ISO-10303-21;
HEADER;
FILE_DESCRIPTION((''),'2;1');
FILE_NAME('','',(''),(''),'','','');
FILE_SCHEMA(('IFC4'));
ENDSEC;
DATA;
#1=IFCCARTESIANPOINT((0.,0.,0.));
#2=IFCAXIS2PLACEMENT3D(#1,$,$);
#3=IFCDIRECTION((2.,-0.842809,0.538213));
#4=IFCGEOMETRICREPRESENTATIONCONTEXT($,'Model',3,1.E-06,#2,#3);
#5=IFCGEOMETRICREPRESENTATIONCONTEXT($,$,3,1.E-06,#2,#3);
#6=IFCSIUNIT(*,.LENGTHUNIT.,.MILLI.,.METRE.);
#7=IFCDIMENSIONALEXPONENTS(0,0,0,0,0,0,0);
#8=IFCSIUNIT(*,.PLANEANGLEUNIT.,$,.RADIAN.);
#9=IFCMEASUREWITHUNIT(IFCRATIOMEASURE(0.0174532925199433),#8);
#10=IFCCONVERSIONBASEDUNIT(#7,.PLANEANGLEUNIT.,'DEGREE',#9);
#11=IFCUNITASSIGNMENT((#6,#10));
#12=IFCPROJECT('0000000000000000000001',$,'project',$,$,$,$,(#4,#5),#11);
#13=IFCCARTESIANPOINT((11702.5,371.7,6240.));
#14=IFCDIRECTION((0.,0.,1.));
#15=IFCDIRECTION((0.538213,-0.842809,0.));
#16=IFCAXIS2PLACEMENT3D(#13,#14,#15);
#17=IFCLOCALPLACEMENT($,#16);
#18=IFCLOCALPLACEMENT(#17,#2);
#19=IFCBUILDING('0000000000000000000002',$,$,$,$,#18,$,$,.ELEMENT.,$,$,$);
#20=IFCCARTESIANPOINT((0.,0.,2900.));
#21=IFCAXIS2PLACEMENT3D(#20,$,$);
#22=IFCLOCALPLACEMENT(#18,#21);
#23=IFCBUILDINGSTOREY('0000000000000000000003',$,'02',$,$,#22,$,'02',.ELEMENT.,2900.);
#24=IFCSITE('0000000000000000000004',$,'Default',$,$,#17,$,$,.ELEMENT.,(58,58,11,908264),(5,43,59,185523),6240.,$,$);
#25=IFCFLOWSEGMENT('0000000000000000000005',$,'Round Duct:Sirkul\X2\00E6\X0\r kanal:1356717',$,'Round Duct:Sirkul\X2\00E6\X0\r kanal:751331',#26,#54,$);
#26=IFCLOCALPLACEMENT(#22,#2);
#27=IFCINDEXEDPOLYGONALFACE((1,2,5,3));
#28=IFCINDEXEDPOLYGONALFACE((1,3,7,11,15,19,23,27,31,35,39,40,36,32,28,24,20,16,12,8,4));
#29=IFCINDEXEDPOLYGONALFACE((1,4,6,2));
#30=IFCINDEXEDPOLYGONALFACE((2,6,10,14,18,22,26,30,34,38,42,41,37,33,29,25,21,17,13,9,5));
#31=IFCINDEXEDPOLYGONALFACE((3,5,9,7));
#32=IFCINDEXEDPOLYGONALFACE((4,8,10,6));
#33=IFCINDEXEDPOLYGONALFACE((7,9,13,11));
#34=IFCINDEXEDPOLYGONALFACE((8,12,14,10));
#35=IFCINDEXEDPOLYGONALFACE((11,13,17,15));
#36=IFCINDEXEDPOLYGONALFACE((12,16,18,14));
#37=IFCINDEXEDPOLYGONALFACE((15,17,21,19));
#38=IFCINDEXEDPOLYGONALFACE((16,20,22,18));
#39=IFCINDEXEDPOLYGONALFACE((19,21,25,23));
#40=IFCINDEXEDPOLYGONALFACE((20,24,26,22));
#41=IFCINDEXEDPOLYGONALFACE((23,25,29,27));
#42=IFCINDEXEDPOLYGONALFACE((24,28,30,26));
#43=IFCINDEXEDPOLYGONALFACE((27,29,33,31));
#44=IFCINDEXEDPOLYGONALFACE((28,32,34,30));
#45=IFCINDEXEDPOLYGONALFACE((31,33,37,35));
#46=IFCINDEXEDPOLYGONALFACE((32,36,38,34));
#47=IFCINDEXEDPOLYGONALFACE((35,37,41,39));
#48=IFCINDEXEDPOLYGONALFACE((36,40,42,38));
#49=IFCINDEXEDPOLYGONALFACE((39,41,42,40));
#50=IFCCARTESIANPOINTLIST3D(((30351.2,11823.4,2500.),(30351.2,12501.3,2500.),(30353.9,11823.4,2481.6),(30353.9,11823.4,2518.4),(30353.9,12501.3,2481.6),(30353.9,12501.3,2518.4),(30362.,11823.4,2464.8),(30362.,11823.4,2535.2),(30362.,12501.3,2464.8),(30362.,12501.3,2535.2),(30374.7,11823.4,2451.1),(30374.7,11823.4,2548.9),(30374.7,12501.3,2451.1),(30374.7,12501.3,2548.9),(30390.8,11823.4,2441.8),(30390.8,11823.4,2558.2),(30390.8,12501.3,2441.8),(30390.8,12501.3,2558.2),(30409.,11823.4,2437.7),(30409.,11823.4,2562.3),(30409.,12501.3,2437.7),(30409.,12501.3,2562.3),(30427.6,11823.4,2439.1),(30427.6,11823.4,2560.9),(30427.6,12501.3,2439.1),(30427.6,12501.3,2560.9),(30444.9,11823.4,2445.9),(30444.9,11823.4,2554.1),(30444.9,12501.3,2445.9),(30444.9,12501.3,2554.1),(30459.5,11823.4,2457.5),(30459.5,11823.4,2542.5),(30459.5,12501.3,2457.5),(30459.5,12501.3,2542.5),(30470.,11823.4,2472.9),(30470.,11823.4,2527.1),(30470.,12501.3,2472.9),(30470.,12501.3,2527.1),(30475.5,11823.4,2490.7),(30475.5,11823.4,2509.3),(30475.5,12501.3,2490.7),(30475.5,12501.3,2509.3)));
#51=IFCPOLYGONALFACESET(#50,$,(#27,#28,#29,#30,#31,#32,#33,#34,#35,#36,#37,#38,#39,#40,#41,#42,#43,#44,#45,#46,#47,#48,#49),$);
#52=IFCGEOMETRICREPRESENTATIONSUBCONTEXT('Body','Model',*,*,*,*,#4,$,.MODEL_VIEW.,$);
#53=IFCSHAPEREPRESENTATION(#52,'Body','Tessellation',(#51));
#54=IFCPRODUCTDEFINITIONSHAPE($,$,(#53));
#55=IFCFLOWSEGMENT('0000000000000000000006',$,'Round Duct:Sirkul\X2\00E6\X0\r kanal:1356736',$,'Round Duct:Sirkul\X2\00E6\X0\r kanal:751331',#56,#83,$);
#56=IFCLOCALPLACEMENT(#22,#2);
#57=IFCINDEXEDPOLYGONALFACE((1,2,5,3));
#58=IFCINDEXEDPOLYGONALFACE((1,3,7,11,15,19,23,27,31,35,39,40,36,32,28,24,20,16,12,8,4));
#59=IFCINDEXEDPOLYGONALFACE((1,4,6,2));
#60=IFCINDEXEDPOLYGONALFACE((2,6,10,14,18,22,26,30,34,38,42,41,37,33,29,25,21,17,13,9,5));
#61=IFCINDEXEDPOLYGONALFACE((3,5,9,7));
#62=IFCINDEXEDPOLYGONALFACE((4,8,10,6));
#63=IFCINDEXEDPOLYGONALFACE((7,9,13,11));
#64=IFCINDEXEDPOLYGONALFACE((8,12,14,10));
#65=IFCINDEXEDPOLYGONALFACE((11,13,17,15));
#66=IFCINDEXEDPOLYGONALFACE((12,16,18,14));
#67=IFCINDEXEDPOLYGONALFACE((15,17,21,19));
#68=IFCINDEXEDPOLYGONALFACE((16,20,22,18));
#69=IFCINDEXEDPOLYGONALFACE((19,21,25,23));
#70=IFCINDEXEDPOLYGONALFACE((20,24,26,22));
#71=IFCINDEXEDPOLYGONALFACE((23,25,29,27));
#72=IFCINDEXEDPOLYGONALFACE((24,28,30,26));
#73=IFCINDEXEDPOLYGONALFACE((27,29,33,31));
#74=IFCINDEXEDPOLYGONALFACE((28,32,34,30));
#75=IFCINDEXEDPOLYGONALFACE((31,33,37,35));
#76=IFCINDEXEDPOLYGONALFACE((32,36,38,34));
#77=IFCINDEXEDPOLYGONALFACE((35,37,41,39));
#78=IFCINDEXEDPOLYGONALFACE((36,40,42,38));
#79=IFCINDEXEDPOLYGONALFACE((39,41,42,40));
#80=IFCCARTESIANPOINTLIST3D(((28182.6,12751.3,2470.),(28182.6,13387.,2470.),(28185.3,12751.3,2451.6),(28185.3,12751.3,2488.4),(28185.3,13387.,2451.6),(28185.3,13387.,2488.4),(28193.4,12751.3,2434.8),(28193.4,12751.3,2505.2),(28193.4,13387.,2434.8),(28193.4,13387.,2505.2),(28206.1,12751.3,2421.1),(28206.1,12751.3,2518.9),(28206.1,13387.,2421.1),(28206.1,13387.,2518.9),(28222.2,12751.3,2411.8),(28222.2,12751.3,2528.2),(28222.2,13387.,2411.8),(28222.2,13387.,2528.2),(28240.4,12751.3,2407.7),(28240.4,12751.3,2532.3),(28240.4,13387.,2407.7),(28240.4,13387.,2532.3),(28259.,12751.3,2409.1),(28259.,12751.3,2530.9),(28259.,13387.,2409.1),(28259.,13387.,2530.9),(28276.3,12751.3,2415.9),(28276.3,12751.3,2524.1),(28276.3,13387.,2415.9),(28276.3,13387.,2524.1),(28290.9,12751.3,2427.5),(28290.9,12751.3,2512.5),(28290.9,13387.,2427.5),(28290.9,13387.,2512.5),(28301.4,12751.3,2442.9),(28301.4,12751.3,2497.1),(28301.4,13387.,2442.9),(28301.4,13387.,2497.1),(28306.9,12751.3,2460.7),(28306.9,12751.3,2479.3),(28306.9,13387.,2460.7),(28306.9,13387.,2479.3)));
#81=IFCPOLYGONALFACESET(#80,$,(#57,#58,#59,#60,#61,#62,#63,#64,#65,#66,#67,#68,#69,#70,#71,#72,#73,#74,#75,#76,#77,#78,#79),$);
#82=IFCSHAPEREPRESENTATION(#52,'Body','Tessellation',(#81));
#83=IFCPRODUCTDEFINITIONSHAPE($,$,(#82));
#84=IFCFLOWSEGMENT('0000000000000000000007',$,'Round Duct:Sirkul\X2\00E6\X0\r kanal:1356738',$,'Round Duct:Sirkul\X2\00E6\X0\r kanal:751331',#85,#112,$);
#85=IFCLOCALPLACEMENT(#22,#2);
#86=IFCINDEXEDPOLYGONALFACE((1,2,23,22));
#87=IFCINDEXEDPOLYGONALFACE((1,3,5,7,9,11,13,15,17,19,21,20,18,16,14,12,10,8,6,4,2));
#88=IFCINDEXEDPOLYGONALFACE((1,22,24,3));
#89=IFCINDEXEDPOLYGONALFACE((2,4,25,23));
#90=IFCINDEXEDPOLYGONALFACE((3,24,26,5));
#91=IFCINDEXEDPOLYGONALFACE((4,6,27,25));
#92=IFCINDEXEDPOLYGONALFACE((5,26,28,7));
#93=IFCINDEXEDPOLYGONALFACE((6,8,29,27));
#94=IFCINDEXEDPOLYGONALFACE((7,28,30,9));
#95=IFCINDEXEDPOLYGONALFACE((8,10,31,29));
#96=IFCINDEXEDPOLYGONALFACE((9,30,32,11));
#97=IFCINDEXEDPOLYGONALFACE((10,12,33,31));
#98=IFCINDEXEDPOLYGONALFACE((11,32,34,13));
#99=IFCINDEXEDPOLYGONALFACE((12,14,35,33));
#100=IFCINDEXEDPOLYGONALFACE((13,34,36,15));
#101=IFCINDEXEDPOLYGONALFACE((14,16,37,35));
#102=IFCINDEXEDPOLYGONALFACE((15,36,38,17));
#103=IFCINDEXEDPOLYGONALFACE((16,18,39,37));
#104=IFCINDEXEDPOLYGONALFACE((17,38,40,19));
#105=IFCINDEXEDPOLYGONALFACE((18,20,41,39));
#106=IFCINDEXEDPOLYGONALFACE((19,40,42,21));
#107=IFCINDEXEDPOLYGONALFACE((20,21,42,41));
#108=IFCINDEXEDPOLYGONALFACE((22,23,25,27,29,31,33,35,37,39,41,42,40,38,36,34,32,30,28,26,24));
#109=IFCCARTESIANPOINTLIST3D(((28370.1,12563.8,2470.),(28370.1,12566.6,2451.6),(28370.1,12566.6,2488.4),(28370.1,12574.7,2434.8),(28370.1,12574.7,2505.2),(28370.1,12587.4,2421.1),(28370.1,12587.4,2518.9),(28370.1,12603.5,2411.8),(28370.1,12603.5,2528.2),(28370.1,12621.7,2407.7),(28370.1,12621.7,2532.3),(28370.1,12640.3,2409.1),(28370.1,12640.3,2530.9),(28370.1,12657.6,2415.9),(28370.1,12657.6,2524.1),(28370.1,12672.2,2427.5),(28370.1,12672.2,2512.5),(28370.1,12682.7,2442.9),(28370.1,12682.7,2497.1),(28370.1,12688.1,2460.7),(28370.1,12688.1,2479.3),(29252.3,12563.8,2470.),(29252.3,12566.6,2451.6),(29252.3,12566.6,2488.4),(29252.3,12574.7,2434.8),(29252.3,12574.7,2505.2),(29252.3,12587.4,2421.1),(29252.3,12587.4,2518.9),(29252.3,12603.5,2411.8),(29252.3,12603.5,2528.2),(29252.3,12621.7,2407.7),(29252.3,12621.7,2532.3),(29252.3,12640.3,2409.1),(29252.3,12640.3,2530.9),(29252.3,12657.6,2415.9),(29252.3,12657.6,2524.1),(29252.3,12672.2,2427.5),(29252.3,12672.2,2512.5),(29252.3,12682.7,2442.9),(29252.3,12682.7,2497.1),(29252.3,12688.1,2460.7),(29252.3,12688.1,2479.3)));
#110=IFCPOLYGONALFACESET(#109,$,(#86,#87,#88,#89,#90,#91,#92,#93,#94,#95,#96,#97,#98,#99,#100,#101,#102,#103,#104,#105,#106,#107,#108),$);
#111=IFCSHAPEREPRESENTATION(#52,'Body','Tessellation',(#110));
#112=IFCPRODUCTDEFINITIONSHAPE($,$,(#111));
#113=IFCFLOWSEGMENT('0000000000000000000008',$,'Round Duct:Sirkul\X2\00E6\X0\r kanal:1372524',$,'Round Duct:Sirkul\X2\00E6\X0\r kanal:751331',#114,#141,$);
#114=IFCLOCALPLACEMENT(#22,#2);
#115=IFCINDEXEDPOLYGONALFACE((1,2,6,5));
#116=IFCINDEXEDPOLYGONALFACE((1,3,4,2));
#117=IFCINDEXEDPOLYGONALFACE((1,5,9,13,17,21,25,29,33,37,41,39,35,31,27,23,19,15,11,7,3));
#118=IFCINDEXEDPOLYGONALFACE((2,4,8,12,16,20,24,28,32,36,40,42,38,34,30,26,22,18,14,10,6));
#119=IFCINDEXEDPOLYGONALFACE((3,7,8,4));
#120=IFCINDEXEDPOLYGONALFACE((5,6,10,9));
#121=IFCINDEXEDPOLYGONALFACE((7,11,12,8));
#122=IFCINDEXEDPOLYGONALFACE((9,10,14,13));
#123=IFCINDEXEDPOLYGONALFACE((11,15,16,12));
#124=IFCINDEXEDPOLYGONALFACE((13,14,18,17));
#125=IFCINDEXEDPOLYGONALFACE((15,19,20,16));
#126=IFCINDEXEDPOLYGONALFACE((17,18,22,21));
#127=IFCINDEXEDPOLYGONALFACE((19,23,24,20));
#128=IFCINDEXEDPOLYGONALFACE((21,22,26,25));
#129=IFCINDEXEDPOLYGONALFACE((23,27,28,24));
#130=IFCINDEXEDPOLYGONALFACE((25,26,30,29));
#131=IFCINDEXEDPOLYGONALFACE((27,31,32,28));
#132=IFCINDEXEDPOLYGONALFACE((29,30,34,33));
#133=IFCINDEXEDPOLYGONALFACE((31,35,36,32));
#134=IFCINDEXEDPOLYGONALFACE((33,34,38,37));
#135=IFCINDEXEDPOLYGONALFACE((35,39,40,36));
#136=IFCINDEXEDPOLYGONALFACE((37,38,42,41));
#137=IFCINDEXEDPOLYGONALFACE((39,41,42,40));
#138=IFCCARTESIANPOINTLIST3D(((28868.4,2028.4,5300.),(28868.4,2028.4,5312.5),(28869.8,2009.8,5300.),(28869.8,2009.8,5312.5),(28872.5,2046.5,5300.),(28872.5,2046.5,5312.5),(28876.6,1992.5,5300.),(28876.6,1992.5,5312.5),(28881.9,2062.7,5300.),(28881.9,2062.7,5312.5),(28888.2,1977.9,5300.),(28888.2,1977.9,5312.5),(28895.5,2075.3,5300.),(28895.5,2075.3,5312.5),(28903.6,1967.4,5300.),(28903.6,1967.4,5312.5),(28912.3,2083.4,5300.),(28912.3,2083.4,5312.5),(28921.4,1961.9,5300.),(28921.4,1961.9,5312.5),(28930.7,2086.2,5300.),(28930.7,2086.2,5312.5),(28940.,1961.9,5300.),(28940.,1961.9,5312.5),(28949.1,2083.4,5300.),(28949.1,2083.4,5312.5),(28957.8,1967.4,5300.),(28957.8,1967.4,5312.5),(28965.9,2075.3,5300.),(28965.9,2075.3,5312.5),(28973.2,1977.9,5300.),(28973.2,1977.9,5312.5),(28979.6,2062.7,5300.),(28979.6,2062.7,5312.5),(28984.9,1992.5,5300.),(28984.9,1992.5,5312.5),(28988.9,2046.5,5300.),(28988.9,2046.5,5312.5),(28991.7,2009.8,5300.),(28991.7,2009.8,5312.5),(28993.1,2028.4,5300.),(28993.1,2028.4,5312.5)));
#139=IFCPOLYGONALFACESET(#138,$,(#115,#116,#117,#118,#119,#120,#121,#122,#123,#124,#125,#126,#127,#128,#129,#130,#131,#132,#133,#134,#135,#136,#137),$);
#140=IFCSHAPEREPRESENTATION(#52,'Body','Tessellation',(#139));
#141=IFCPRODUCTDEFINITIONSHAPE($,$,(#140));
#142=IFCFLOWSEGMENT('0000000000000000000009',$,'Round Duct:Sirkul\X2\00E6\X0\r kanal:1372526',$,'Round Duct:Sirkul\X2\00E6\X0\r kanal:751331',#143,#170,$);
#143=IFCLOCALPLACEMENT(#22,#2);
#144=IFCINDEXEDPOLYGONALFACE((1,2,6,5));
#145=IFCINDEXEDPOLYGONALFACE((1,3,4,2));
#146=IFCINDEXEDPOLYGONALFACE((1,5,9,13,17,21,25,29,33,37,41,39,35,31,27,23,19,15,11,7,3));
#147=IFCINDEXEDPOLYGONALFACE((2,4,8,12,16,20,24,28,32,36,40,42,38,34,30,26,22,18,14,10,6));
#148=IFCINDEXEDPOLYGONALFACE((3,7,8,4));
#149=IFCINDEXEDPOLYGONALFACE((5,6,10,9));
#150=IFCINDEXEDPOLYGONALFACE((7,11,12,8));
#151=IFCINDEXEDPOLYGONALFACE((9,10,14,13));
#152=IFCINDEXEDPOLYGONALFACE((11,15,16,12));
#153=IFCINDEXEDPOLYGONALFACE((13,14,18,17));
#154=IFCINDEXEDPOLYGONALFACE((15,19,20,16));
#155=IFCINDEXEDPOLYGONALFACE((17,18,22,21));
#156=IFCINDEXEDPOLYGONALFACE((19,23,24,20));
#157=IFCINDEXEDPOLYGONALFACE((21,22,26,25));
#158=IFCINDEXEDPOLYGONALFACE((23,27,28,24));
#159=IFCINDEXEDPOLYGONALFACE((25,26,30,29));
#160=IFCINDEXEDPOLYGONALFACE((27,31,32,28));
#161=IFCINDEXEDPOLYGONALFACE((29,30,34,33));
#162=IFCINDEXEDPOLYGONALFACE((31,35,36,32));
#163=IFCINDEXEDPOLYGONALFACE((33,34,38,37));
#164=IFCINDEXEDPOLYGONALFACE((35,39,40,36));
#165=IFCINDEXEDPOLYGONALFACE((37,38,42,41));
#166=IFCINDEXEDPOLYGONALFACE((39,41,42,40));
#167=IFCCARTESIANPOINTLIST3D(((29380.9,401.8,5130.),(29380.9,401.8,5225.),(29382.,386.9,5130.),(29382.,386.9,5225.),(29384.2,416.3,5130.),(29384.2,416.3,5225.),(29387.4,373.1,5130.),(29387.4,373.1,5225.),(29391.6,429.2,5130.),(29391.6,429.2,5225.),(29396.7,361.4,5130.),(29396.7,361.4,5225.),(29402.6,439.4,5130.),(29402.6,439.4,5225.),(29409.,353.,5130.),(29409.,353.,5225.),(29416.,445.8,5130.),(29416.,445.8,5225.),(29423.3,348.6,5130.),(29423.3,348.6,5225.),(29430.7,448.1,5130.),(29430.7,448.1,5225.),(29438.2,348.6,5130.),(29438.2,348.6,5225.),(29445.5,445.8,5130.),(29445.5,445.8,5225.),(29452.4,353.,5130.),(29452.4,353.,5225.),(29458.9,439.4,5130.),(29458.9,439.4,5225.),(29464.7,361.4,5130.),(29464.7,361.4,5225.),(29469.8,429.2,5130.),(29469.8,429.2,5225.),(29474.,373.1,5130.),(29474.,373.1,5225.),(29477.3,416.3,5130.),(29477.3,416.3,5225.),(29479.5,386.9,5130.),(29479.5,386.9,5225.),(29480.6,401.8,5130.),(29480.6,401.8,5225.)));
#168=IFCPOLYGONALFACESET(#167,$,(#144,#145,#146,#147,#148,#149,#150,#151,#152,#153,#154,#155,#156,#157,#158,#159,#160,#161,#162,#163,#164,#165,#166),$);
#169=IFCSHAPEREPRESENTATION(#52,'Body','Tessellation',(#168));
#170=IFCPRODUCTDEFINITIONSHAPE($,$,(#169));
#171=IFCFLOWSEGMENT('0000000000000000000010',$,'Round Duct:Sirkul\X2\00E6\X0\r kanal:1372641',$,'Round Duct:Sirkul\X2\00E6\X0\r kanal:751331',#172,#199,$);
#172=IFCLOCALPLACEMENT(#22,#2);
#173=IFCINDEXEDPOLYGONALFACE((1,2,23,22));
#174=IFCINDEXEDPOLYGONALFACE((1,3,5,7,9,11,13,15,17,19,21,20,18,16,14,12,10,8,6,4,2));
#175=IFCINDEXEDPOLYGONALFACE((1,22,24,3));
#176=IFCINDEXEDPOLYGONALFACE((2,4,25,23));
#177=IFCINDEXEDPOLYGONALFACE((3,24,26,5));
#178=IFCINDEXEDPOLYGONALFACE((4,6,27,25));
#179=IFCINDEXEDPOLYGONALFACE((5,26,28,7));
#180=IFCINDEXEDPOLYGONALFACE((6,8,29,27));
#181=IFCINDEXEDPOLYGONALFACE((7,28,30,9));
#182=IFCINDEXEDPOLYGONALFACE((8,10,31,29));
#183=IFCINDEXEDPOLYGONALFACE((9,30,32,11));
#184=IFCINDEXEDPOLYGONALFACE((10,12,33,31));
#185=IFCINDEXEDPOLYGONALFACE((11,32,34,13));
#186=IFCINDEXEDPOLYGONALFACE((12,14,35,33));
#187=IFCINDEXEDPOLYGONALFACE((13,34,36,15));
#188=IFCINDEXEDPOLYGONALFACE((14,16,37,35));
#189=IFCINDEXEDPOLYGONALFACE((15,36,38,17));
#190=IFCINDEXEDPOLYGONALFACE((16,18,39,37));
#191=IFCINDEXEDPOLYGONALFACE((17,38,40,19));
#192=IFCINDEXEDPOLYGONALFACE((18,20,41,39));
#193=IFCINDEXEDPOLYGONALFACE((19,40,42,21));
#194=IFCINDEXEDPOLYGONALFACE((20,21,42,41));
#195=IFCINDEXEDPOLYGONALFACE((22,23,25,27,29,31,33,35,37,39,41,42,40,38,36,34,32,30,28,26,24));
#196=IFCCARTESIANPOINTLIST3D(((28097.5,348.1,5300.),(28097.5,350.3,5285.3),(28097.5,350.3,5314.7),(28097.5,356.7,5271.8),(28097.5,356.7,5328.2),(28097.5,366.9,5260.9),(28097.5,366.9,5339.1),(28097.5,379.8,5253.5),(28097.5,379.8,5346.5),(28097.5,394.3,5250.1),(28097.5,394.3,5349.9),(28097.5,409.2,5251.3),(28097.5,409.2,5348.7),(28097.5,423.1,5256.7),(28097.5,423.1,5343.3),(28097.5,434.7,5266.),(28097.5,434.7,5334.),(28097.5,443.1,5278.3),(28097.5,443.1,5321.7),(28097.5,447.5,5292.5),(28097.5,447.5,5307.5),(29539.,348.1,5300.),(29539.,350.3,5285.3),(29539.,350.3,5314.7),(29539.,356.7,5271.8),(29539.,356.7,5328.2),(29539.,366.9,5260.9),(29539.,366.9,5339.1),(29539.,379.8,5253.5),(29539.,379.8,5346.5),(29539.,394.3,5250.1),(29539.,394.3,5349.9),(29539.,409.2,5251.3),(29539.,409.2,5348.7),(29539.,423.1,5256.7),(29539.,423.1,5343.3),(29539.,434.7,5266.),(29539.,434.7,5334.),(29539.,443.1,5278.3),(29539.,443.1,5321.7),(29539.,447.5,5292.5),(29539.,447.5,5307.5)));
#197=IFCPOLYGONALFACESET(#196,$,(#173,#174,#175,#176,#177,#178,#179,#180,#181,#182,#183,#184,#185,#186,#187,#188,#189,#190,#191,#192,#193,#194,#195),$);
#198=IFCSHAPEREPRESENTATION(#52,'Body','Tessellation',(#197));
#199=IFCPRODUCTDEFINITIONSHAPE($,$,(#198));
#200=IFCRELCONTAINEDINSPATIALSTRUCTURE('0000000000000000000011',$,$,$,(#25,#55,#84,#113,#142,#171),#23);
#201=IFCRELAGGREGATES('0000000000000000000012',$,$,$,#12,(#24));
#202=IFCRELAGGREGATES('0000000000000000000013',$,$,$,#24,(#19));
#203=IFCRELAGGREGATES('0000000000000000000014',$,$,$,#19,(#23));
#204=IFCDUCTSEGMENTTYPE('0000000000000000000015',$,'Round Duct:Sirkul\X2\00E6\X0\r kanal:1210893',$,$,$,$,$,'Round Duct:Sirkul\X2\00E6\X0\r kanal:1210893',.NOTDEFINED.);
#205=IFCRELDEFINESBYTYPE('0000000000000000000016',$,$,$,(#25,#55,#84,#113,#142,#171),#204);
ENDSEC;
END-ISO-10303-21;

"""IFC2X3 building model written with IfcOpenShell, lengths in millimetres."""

from ifc_helpers import new_model, entity, si_unit, converted_unit, direction, frame, frame_2d, origin, origin_2d_with_axis, place, context, subcontext, project, spatial, circle, extrude, type_object, element, save


model = new_model("IFC2X3")

# Units and contexts
model_context = context("Model", 3, precision=1e-06, world=origin(), true_north=direction((2.0, -0.842809, 0.538213)))
context_of_model = context(None, 3, precision=1e-06, world=origin(), true_north=direction((2.0, -0.842809, 0.538213)))
body_context = subcontext(model_context, "Body", "Model", "MODEL_VIEW")
ifc_project = project(units=[si_unit("LENGTHUNIT", "METRE", prefix="MILLI"), converted_unit("PLANEANGLEUNIT", "DEGREE", entity("IfcRatioMeasure", 0.0174532925199433), si_unit("PLANEANGLEUNIT", "RADIAN"), dimensions=[0, 0, 0, 0, 0, 0, 0])], contexts=[model_context, context_of_model])

# Site, building, storey
site_placement = place(None, frame((11702.5, 371.7, 6240.0), z_axis=(0.0, 0.0, 1.0), x_axis=(0.538213, -0.842809, 0.0)))
site = spatial("IfcSite", under=ifc_project, at=site_placement, Name="Default", CompositionType="ELEMENT", RefLatitude=(58, 58, 11, 908264), RefLongitude=(5, 43, 59, 185523), RefElevation=6240.0)
building_placement = place(site_placement, origin())
building = spatial("IfcBuilding", under=site, at=building_placement, CompositionType="ELEMENT")
storey_placement = place(building_placement, frame((0.0, 0.0, 2900.0)))
storey = spatial("IfcBuildingStorey", under=building, at=storey_placement, Name="02", LongName="02", CompositionType="ELEMENT", Elevation=2900.0)

# Flow segments
duct_segment_type = type_object("IfcDuctSegmentType", Name="Round Duct:Sirkulær kanal:1210893", ElementType="Round Duct:Sirkulær kanal:1210893", PredefinedType="NOTDEFINED")
flow_segment_1_placement = place(storey_placement, origin())
element("IfcFlowSegment", 1, at=flow_segment_1_placement, inside=storey, type_object=duct_segment_type, Name="Round Duct:Sirkulær kanal:1356717", ObjectType="Round Duct:Sirkulær kanal:751331", context=body_context, shape_type="SweptSolid", body=[
    extrude(circle(Radius=62.5, at=frame_2d((0.0, 0.0), x_axis=(1.0, 0.0))), frame((30413.7, 11823.4, 2500.0), z_axis=(0.0, 1.0, 0.0), x_axis=(-1.0, 0.0, 0.0)), (0.0, 0.0, 1.0), 677.9),
])
flow_segment_2_placement = place(storey_placement, origin())
element("IfcFlowSegment", 2, at=flow_segment_2_placement, inside=storey, type_object=duct_segment_type, Name="Round Duct:Sirkulær kanal:1356736", ObjectType="Round Duct:Sirkulær kanal:751331", context=body_context, shape_type="SweptSolid", body=[
    extrude(circle(Radius=62.5, at=origin_2d_with_axis()), frame((28245.1, 12751.3, 2470.0), z_axis=(0.0, 1.0, 0.0), x_axis=(-1.0, 0.0, 0.0)), (0.0, 0.0, 1.0), 635.7),
])
flow_segment_3_placement = place(storey_placement, origin())
element("IfcFlowSegment", 3, at=flow_segment_3_placement, inside=storey, type_object=duct_segment_type, Name="Round Duct:Sirkulær kanal:1356738", ObjectType="Round Duct:Sirkulær kanal:751331", context=body_context, shape_type="SweptSolid", body=[
    extrude(circle(Radius=62.5, at=origin_2d_with_axis()), frame((28370.1, 12626.3, 2470.0), z_axis=(1.0, 0.0, 0.0), x_axis=(0.0, -1.0, 0.0)), (0.0, 0.0, 1.0), 882.2),
])
flow_segment_4_placement = place(storey_placement, origin())
element("IfcFlowSegment", 4, at=flow_segment_4_placement, inside=storey, type_object=duct_segment_type, Name="Round Duct:Sirkulær kanal:1372524", ObjectType="Round Duct:Sirkulær kanal:751331", context=body_context, shape_type="SweptSolid", body=[
    extrude(circle(Radius=62.5, at=frame_2d((0.0, 0.0), x_axis=(1.0, 0.0))), frame((28930.7, 2023.7, 5300.0), z_axis=(0.0, 0.0, 1.0), x_axis=(0.0, 1.0, 0.0)), (0.0, 0.0, 1.0), 12.5),
])
flow_segment_5_placement = place(storey_placement, origin())
element("IfcFlowSegment", 5, at=flow_segment_5_placement, inside=storey, type_object=duct_segment_type, Name="Round Duct:Sirkulær kanal:1372526", ObjectType="Round Duct:Sirkulær kanal:751331", context=body_context, shape_type="SweptSolid", body=[
    extrude(circle(Radius=50.0, at=frame_2d((0.0, 0.0), x_axis=(1.0, 0.0))), frame((29430.7, 398.1, 5130.0), z_axis=(0.0, 0.0, 1.0), x_axis=(0.0, 1.0, 0.0)), (0.0, 0.0, 1.0), 95.0),
])
flow_segment_6_placement = place(storey_placement, origin())
element("IfcFlowSegment", 6, at=flow_segment_6_placement, inside=storey, type_object=duct_segment_type, Name="Round Duct:Sirkulær kanal:1372641", ObjectType="Round Duct:Sirkulær kanal:751331", context=body_context, shape_type="SweptSolid", body=[
    extrude(circle(Radius=50.0, at=frame_2d((0.0, 0.0), x_axis=(1.0, 0.0))), frame((28097.5, 398.1, 5300.0), z_axis=(1.0, 0.0, 0.0), x_axis=(0.0, -1.0, 0.0)), (0.0, 0.0, 1.0), 1441.5),
])

save(model, "model.ifc")
